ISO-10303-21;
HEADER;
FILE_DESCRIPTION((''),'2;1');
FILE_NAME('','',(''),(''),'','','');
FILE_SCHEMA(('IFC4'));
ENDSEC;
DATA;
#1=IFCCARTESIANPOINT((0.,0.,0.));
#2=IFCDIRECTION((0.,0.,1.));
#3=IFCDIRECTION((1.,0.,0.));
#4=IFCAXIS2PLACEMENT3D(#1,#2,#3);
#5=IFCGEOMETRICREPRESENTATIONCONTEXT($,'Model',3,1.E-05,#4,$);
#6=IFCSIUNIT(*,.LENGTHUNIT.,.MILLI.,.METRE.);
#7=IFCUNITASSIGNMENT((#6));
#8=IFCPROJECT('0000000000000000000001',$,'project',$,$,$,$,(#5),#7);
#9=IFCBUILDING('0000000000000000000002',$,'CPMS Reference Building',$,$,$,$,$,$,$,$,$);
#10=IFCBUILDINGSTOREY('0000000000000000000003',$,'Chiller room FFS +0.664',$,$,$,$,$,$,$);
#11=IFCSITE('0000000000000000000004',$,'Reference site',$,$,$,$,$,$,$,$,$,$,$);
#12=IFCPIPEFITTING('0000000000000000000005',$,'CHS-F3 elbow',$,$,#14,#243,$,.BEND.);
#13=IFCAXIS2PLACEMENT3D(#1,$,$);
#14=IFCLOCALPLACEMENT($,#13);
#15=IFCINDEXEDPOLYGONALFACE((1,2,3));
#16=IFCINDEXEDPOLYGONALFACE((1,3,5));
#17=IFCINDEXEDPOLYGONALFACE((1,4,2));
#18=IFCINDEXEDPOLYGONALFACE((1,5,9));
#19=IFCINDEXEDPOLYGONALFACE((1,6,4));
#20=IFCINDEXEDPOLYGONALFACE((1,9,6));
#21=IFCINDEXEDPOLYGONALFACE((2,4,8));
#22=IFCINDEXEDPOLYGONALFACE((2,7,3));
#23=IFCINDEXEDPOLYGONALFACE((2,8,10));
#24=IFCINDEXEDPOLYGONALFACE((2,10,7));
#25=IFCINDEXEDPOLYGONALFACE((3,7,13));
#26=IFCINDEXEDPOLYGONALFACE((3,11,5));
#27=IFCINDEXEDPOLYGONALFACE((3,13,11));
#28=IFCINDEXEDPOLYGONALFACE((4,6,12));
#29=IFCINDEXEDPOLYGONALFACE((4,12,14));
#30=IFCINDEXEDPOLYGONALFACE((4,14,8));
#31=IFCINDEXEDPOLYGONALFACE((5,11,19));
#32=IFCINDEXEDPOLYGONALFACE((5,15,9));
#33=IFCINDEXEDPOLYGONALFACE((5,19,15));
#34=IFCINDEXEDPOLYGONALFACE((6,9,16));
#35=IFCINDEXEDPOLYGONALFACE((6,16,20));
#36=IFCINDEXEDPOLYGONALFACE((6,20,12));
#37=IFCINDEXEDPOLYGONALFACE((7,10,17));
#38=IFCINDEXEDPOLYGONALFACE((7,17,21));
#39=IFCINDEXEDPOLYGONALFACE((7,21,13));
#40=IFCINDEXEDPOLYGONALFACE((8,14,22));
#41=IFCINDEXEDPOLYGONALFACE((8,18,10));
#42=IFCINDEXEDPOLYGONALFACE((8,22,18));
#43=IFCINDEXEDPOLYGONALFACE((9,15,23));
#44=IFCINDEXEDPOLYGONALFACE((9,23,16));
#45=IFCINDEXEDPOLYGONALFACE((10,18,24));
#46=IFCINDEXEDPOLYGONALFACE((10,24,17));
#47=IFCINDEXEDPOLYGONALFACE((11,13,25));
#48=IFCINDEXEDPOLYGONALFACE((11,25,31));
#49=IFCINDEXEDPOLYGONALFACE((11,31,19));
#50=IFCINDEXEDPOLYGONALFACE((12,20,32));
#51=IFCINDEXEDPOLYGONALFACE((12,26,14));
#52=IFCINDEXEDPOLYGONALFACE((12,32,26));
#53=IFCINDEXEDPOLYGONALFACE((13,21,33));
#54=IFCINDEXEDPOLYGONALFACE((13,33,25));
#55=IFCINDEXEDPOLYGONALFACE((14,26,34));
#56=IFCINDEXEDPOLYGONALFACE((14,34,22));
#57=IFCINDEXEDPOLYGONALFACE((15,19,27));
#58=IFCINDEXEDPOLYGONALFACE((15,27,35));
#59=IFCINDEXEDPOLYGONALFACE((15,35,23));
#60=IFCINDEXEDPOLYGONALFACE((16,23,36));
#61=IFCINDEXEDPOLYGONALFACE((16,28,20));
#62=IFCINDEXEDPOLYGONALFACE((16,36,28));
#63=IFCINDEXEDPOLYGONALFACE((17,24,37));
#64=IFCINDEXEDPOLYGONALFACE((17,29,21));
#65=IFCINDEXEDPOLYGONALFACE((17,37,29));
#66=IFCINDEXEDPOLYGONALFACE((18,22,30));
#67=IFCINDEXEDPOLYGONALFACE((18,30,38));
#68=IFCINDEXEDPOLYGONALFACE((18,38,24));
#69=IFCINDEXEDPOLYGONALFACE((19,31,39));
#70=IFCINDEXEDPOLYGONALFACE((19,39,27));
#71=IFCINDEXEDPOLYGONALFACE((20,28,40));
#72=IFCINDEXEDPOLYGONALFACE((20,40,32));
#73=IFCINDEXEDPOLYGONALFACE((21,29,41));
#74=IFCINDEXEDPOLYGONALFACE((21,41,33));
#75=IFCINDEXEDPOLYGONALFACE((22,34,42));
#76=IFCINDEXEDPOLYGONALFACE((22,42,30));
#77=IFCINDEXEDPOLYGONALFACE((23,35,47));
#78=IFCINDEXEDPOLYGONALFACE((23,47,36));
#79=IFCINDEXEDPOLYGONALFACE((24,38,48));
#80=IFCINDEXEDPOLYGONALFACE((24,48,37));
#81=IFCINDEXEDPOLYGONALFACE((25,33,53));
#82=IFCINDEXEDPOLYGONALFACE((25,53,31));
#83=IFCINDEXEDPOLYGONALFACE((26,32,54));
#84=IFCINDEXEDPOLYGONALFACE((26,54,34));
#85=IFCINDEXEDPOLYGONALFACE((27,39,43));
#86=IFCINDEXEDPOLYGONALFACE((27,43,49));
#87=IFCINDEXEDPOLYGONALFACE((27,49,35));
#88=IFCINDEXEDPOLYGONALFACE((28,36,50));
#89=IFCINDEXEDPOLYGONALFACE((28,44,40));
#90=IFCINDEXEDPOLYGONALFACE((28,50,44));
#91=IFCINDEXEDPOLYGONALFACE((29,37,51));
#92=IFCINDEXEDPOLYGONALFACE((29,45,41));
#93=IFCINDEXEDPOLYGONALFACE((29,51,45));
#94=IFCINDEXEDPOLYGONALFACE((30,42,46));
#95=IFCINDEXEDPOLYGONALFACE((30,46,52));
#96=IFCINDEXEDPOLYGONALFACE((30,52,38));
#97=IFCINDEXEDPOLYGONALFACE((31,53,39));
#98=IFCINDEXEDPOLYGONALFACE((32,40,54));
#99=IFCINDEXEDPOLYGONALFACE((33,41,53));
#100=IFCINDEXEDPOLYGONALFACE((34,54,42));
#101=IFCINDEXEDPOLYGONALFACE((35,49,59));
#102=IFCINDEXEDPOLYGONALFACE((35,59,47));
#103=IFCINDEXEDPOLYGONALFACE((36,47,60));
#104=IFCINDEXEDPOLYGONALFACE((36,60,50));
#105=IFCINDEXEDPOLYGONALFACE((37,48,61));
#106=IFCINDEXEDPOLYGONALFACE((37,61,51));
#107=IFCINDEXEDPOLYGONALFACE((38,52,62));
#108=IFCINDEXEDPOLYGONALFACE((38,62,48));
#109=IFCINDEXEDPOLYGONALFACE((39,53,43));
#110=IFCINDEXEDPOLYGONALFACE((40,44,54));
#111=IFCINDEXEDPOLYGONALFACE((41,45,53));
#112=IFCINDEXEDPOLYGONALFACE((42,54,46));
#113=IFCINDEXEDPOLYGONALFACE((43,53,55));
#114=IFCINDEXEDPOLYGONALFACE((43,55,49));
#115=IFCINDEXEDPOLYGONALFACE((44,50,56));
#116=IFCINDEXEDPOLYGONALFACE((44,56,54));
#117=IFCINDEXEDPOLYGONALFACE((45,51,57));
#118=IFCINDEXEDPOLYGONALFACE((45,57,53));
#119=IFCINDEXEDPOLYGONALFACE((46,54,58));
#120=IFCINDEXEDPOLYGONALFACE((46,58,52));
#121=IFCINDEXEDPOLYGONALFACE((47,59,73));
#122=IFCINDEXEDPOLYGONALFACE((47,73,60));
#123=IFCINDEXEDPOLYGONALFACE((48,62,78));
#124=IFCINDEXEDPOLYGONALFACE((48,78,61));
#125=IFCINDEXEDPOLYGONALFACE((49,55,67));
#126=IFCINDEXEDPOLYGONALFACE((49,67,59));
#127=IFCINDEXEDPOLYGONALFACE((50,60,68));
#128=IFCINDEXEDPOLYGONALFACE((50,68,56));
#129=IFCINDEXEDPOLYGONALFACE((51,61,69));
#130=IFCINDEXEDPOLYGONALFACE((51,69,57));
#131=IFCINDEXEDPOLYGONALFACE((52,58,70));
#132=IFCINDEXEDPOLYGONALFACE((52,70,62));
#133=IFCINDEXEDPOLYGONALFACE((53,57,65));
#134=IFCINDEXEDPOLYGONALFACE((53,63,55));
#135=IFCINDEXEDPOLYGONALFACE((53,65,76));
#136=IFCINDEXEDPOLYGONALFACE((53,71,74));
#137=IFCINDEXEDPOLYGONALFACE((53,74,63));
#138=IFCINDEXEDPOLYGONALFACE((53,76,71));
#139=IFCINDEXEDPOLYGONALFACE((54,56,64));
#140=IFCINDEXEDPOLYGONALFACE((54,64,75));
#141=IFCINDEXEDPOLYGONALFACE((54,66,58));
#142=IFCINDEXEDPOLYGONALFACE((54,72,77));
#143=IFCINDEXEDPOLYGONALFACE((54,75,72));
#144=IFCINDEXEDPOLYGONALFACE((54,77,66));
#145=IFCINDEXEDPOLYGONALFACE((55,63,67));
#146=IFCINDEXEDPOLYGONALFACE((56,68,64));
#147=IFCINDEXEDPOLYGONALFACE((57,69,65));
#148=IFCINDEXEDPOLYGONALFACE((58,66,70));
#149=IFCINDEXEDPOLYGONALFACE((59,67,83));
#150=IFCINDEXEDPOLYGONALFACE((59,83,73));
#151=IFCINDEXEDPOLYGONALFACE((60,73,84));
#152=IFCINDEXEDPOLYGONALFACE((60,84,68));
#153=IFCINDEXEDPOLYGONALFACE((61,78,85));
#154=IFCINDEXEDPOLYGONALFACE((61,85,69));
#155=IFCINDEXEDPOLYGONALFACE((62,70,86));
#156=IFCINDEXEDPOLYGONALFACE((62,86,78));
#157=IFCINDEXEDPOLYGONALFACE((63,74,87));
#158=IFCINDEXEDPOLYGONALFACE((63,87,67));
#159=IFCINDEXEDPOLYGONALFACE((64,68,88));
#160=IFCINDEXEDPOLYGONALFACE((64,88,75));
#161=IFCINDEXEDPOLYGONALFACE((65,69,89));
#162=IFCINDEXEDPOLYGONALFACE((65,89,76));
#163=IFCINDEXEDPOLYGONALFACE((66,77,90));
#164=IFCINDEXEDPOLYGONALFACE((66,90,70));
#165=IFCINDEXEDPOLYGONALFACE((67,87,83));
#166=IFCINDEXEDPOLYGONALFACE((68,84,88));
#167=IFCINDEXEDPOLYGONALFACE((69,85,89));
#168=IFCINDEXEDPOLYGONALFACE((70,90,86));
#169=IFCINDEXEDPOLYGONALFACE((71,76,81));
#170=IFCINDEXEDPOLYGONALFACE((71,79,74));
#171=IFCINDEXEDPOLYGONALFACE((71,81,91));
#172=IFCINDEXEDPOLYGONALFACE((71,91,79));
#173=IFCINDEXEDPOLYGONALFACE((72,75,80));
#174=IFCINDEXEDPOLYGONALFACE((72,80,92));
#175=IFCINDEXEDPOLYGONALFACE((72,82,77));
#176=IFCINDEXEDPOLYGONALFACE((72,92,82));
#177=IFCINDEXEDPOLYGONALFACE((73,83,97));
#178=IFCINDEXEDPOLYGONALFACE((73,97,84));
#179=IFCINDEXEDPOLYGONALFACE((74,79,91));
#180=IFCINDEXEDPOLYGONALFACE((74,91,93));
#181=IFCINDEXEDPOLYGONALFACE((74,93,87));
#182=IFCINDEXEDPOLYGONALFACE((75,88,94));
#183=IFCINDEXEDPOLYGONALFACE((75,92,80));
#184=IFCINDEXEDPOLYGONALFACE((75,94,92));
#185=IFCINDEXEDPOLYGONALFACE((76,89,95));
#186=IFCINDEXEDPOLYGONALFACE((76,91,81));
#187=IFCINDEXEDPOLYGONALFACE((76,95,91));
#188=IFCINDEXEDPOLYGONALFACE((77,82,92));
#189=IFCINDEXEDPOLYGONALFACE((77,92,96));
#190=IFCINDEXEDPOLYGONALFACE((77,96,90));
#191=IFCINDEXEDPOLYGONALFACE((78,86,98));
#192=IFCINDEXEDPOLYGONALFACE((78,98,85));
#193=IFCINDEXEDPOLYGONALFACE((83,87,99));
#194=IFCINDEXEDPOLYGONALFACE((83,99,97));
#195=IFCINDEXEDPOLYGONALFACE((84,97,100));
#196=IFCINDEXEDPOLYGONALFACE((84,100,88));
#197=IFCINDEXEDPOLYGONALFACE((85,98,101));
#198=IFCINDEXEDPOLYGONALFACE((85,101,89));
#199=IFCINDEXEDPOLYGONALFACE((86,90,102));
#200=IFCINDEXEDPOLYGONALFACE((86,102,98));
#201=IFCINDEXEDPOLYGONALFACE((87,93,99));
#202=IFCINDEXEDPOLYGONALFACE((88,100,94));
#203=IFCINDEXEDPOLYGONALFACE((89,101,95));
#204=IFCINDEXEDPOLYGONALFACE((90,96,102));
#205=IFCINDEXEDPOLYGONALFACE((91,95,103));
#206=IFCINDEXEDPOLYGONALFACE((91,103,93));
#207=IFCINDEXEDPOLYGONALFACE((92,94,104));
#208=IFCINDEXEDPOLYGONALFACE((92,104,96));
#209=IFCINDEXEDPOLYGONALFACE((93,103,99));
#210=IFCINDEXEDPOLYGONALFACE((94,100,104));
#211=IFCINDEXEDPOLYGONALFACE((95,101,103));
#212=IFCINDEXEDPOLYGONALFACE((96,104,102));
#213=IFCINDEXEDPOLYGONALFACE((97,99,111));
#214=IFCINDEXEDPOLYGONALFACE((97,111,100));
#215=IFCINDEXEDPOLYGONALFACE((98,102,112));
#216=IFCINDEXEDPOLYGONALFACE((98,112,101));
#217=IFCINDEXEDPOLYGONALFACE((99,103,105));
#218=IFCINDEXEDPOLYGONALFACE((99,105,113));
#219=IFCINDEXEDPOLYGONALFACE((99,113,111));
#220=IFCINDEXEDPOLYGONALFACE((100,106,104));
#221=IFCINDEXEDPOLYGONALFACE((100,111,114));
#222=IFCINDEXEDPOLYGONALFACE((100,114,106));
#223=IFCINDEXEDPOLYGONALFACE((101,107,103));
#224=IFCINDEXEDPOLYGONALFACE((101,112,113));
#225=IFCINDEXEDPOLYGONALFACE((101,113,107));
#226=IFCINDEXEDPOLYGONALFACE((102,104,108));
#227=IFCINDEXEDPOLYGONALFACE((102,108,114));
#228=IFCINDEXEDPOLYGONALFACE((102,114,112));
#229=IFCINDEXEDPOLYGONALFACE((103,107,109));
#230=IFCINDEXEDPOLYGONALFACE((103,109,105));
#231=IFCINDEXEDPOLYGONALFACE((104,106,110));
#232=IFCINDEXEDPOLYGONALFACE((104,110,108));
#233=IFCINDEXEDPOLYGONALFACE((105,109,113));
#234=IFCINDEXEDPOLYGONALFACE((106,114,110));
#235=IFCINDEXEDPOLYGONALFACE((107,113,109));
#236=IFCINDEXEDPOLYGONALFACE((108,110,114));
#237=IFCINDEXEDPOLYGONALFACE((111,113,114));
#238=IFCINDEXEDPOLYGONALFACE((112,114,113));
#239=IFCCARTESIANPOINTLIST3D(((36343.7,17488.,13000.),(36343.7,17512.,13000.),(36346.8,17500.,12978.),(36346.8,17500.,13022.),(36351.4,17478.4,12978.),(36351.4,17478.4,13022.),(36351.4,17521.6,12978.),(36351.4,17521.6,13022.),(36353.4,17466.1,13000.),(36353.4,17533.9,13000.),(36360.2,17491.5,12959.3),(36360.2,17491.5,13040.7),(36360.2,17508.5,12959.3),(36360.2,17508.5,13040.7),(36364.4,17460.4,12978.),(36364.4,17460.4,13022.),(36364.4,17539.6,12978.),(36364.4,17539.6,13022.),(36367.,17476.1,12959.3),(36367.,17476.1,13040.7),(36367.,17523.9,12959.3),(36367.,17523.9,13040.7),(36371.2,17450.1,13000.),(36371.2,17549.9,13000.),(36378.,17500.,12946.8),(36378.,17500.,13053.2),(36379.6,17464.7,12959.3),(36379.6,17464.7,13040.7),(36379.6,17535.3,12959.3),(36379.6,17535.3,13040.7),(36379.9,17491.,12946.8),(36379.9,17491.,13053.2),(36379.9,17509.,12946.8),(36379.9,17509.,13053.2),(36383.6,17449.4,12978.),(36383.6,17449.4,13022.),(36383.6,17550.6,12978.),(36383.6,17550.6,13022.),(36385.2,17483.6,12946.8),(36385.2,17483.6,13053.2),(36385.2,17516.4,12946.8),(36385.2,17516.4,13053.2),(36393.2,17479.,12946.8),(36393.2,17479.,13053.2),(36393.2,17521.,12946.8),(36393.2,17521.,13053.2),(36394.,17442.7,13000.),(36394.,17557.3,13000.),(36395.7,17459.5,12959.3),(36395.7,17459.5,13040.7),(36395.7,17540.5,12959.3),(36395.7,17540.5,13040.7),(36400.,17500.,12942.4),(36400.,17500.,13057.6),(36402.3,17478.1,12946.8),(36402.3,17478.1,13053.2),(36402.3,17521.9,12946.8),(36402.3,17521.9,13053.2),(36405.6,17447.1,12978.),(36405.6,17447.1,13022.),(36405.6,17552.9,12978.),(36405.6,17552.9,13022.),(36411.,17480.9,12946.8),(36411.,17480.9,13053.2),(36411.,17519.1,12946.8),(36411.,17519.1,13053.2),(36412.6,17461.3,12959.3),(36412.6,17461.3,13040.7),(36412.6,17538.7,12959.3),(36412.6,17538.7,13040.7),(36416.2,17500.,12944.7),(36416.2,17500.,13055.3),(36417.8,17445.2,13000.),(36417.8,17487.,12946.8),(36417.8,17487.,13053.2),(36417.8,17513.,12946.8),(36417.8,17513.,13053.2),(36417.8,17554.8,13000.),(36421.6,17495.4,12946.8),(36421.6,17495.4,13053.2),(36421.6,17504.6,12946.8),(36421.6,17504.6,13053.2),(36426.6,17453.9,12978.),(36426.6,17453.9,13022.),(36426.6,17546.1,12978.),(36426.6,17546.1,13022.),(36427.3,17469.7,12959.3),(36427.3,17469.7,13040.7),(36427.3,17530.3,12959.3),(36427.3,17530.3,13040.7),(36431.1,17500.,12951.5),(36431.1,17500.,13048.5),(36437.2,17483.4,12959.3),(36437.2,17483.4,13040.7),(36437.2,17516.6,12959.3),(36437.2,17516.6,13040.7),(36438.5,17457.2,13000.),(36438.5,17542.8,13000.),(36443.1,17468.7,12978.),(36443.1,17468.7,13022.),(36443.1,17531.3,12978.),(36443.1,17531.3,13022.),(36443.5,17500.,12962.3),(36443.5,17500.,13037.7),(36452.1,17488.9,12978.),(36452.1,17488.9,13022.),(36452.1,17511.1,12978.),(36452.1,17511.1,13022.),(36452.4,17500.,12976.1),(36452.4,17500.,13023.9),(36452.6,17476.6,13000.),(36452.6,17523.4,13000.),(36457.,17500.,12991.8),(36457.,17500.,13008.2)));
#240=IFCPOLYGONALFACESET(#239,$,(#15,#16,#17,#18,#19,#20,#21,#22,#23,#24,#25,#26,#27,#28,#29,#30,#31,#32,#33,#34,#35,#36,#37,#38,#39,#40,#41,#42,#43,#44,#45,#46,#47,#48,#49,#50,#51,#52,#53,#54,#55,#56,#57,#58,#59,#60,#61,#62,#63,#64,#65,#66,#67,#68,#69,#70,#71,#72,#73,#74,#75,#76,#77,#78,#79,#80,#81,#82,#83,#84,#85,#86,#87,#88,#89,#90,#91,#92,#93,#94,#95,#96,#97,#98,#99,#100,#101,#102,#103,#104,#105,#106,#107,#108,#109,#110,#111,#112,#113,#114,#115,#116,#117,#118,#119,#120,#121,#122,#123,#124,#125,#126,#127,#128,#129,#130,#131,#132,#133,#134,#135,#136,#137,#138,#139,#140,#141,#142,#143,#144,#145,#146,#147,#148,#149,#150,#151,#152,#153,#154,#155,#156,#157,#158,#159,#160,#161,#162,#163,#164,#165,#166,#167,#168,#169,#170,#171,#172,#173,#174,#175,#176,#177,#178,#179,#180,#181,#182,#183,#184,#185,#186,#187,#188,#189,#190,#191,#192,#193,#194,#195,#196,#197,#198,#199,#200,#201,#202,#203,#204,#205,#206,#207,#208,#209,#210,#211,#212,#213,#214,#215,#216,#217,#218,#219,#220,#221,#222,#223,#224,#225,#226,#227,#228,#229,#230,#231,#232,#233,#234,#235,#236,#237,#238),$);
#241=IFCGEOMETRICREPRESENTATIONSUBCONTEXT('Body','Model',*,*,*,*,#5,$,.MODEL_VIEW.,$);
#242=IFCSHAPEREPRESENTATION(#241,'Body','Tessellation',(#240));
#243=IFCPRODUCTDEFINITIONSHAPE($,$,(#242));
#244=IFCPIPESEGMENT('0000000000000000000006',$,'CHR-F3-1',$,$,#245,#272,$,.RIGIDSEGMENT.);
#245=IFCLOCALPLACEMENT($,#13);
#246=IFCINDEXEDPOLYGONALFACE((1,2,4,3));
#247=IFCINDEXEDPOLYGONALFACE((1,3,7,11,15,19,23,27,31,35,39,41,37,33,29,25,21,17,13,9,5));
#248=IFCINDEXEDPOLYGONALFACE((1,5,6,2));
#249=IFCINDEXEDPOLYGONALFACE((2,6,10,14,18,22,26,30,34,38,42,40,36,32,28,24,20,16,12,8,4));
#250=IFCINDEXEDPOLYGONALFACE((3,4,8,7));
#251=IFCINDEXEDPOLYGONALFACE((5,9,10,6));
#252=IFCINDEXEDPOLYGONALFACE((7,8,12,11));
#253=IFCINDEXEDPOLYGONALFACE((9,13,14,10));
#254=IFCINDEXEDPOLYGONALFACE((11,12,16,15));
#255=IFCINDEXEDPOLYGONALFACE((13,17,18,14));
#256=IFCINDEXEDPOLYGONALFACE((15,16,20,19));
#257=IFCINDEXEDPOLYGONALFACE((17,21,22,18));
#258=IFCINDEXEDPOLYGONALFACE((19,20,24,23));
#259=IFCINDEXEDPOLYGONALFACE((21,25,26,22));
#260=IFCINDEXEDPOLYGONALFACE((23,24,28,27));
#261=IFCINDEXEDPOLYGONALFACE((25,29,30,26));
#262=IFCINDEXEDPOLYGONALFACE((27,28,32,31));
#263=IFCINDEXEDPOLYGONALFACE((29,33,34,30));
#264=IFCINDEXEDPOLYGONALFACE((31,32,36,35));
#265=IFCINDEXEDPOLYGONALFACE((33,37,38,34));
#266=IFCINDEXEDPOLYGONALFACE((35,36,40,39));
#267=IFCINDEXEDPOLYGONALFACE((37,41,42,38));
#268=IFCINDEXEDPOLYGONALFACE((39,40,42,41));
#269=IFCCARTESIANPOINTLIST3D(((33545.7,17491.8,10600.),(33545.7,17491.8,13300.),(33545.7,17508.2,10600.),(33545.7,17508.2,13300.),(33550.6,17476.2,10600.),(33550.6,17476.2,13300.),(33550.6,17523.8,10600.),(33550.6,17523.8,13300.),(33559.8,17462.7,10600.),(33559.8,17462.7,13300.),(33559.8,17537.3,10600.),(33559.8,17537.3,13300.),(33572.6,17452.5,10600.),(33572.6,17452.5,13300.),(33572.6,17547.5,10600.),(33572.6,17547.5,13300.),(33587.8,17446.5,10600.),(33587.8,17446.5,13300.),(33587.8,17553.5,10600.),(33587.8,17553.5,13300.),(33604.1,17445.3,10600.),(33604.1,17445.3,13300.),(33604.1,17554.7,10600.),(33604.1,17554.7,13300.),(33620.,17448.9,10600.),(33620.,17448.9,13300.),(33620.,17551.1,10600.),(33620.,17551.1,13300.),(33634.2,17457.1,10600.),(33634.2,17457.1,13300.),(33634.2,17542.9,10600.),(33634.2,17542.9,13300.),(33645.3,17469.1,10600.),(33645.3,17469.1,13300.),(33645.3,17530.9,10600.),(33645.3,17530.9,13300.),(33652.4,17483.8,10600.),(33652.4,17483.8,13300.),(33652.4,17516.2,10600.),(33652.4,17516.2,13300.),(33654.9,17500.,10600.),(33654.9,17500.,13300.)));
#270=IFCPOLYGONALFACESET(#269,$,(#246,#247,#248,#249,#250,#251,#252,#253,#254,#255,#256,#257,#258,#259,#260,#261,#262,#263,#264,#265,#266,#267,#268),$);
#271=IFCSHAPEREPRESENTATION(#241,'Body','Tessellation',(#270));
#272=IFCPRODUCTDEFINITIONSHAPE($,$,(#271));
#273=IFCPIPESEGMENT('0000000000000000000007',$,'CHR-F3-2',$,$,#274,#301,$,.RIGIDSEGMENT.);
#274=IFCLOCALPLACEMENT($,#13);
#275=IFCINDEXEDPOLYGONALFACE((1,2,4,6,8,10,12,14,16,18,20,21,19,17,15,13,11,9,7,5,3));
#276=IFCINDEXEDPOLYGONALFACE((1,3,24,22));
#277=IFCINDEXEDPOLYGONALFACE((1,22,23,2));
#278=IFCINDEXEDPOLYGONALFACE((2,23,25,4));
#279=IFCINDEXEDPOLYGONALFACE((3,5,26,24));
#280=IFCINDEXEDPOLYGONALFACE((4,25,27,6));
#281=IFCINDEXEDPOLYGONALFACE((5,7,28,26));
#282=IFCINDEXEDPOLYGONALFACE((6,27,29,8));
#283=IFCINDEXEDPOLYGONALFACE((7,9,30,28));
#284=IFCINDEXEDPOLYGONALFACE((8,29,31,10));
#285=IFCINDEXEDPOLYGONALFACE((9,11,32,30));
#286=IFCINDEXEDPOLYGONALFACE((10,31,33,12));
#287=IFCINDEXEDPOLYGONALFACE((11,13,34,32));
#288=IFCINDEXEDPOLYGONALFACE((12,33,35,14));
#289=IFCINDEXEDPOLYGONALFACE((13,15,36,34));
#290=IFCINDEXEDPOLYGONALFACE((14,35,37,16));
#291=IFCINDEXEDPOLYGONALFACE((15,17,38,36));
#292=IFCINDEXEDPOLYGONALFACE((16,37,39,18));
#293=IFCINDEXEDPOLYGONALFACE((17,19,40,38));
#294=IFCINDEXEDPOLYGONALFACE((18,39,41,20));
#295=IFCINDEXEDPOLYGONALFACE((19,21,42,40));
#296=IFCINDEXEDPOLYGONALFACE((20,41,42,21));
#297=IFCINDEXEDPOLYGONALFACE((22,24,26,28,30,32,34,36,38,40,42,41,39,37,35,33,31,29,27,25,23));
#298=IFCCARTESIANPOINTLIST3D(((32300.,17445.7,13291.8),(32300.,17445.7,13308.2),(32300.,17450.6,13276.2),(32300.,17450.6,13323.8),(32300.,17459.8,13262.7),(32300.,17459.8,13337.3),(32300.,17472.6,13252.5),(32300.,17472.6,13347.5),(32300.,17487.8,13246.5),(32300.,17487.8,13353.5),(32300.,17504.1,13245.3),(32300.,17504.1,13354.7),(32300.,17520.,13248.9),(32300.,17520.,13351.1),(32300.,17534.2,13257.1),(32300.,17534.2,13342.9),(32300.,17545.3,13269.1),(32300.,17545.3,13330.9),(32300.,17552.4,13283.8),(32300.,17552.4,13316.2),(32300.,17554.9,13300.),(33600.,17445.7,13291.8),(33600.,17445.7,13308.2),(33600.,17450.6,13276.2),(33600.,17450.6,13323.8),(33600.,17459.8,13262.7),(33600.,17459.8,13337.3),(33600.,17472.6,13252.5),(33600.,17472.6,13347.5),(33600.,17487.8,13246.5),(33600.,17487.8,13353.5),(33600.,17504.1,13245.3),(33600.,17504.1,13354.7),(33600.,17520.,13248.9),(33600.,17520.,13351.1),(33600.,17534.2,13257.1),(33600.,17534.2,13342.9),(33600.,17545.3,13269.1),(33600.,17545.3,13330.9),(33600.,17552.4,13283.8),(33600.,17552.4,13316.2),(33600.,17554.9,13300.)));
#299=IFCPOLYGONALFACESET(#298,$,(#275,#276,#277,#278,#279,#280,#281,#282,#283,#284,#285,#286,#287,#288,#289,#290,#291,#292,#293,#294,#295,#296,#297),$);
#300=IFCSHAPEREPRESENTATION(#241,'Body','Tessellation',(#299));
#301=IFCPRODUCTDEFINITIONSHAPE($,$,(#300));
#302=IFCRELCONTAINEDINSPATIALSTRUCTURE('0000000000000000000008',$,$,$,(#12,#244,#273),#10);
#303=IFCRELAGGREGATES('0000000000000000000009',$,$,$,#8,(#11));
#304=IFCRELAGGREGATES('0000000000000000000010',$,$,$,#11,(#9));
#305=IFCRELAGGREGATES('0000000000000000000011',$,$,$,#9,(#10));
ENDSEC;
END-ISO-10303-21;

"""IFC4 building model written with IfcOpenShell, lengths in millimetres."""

from ifc_helpers import new_model, entity, si_unit, frame, origin_with_axes, origin_2d, place, context, subcontext, project, spatial, circle_curve, outline, extrude, element, save


model = new_model("IFC4")

# Units and contexts
model_context = context("Model", 3, precision=1e-05, world=origin_with_axes())
body_context = subcontext(model_context, "Body", "Model", "MODEL_VIEW")
ifc_project = project(units=[si_unit("LENGTHUNIT", "METRE", prefix="MILLI")], contexts=[model_context])

# Site, building, storey
site = spatial("IfcSite", under=ifc_project, Name="Reference site")
building = spatial("IfcBuilding", under=site, Name="CPMS Reference Building")
storey = spatial("IfcBuildingStorey", under=building, Name="Chiller room FFS +0.664")

# Pipe fitting
pipe_fitting_1_placement = place(None, origin_with_axes())
element("IfcPipeFitting", 1, at=pipe_fitting_1_placement, inside=storey, Name="CHS-F3 elbow", PredefinedType="BEND", context=body_context, shape_type="CSG", body=[
    entity("IfcSphere", entity("IfcAxis2Placement3D", entity("IfcCartesianPoint", [36400.0, 17500.0, 13000.0]), entity("IfcDirection", [0.0, 0.0, 1.0]), entity("IfcDirection", [1.0, 0.0, 0.0])), 57.6),
])

# Pipe segments
pipe_segment_1_placement = place(None, origin_with_axes())
element("IfcPipeSegment", 2, at=pipe_segment_1_placement, inside=storey, Name="CHR-F3-1", PredefinedType="RIGIDSEGMENT", context=body_context, shape_type="SweptSolid", body=[
    extrude(outline(circle_curve(origin_2d(), 54.9)), frame((33600.0, 17500.0, 10600.0), z_axis=(0.0, 0.0, 1.0), x_axis=(1.0, 0.0, 0.0)), (0.0, 0.0, 1.0), 2700.0),
])
pipe_segment_2_placement = place(None, origin_with_axes())
element("IfcPipeSegment", 3, at=pipe_segment_2_placement, inside=storey, Name="CHR-F3-2", PredefinedType="RIGIDSEGMENT", context=body_context, shape_type="SweptSolid", body=[
    extrude(outline(circle_curve(origin_2d(), 54.9)), frame((33600.0, 17500.0, 13300.0), z_axis=(-1.0, 0.0, 0.0), x_axis=(0.0, 1.0, 0.0)), (0.0, 0.0, 1.0), 1300.0),
])

save(model, "model.ifc")
